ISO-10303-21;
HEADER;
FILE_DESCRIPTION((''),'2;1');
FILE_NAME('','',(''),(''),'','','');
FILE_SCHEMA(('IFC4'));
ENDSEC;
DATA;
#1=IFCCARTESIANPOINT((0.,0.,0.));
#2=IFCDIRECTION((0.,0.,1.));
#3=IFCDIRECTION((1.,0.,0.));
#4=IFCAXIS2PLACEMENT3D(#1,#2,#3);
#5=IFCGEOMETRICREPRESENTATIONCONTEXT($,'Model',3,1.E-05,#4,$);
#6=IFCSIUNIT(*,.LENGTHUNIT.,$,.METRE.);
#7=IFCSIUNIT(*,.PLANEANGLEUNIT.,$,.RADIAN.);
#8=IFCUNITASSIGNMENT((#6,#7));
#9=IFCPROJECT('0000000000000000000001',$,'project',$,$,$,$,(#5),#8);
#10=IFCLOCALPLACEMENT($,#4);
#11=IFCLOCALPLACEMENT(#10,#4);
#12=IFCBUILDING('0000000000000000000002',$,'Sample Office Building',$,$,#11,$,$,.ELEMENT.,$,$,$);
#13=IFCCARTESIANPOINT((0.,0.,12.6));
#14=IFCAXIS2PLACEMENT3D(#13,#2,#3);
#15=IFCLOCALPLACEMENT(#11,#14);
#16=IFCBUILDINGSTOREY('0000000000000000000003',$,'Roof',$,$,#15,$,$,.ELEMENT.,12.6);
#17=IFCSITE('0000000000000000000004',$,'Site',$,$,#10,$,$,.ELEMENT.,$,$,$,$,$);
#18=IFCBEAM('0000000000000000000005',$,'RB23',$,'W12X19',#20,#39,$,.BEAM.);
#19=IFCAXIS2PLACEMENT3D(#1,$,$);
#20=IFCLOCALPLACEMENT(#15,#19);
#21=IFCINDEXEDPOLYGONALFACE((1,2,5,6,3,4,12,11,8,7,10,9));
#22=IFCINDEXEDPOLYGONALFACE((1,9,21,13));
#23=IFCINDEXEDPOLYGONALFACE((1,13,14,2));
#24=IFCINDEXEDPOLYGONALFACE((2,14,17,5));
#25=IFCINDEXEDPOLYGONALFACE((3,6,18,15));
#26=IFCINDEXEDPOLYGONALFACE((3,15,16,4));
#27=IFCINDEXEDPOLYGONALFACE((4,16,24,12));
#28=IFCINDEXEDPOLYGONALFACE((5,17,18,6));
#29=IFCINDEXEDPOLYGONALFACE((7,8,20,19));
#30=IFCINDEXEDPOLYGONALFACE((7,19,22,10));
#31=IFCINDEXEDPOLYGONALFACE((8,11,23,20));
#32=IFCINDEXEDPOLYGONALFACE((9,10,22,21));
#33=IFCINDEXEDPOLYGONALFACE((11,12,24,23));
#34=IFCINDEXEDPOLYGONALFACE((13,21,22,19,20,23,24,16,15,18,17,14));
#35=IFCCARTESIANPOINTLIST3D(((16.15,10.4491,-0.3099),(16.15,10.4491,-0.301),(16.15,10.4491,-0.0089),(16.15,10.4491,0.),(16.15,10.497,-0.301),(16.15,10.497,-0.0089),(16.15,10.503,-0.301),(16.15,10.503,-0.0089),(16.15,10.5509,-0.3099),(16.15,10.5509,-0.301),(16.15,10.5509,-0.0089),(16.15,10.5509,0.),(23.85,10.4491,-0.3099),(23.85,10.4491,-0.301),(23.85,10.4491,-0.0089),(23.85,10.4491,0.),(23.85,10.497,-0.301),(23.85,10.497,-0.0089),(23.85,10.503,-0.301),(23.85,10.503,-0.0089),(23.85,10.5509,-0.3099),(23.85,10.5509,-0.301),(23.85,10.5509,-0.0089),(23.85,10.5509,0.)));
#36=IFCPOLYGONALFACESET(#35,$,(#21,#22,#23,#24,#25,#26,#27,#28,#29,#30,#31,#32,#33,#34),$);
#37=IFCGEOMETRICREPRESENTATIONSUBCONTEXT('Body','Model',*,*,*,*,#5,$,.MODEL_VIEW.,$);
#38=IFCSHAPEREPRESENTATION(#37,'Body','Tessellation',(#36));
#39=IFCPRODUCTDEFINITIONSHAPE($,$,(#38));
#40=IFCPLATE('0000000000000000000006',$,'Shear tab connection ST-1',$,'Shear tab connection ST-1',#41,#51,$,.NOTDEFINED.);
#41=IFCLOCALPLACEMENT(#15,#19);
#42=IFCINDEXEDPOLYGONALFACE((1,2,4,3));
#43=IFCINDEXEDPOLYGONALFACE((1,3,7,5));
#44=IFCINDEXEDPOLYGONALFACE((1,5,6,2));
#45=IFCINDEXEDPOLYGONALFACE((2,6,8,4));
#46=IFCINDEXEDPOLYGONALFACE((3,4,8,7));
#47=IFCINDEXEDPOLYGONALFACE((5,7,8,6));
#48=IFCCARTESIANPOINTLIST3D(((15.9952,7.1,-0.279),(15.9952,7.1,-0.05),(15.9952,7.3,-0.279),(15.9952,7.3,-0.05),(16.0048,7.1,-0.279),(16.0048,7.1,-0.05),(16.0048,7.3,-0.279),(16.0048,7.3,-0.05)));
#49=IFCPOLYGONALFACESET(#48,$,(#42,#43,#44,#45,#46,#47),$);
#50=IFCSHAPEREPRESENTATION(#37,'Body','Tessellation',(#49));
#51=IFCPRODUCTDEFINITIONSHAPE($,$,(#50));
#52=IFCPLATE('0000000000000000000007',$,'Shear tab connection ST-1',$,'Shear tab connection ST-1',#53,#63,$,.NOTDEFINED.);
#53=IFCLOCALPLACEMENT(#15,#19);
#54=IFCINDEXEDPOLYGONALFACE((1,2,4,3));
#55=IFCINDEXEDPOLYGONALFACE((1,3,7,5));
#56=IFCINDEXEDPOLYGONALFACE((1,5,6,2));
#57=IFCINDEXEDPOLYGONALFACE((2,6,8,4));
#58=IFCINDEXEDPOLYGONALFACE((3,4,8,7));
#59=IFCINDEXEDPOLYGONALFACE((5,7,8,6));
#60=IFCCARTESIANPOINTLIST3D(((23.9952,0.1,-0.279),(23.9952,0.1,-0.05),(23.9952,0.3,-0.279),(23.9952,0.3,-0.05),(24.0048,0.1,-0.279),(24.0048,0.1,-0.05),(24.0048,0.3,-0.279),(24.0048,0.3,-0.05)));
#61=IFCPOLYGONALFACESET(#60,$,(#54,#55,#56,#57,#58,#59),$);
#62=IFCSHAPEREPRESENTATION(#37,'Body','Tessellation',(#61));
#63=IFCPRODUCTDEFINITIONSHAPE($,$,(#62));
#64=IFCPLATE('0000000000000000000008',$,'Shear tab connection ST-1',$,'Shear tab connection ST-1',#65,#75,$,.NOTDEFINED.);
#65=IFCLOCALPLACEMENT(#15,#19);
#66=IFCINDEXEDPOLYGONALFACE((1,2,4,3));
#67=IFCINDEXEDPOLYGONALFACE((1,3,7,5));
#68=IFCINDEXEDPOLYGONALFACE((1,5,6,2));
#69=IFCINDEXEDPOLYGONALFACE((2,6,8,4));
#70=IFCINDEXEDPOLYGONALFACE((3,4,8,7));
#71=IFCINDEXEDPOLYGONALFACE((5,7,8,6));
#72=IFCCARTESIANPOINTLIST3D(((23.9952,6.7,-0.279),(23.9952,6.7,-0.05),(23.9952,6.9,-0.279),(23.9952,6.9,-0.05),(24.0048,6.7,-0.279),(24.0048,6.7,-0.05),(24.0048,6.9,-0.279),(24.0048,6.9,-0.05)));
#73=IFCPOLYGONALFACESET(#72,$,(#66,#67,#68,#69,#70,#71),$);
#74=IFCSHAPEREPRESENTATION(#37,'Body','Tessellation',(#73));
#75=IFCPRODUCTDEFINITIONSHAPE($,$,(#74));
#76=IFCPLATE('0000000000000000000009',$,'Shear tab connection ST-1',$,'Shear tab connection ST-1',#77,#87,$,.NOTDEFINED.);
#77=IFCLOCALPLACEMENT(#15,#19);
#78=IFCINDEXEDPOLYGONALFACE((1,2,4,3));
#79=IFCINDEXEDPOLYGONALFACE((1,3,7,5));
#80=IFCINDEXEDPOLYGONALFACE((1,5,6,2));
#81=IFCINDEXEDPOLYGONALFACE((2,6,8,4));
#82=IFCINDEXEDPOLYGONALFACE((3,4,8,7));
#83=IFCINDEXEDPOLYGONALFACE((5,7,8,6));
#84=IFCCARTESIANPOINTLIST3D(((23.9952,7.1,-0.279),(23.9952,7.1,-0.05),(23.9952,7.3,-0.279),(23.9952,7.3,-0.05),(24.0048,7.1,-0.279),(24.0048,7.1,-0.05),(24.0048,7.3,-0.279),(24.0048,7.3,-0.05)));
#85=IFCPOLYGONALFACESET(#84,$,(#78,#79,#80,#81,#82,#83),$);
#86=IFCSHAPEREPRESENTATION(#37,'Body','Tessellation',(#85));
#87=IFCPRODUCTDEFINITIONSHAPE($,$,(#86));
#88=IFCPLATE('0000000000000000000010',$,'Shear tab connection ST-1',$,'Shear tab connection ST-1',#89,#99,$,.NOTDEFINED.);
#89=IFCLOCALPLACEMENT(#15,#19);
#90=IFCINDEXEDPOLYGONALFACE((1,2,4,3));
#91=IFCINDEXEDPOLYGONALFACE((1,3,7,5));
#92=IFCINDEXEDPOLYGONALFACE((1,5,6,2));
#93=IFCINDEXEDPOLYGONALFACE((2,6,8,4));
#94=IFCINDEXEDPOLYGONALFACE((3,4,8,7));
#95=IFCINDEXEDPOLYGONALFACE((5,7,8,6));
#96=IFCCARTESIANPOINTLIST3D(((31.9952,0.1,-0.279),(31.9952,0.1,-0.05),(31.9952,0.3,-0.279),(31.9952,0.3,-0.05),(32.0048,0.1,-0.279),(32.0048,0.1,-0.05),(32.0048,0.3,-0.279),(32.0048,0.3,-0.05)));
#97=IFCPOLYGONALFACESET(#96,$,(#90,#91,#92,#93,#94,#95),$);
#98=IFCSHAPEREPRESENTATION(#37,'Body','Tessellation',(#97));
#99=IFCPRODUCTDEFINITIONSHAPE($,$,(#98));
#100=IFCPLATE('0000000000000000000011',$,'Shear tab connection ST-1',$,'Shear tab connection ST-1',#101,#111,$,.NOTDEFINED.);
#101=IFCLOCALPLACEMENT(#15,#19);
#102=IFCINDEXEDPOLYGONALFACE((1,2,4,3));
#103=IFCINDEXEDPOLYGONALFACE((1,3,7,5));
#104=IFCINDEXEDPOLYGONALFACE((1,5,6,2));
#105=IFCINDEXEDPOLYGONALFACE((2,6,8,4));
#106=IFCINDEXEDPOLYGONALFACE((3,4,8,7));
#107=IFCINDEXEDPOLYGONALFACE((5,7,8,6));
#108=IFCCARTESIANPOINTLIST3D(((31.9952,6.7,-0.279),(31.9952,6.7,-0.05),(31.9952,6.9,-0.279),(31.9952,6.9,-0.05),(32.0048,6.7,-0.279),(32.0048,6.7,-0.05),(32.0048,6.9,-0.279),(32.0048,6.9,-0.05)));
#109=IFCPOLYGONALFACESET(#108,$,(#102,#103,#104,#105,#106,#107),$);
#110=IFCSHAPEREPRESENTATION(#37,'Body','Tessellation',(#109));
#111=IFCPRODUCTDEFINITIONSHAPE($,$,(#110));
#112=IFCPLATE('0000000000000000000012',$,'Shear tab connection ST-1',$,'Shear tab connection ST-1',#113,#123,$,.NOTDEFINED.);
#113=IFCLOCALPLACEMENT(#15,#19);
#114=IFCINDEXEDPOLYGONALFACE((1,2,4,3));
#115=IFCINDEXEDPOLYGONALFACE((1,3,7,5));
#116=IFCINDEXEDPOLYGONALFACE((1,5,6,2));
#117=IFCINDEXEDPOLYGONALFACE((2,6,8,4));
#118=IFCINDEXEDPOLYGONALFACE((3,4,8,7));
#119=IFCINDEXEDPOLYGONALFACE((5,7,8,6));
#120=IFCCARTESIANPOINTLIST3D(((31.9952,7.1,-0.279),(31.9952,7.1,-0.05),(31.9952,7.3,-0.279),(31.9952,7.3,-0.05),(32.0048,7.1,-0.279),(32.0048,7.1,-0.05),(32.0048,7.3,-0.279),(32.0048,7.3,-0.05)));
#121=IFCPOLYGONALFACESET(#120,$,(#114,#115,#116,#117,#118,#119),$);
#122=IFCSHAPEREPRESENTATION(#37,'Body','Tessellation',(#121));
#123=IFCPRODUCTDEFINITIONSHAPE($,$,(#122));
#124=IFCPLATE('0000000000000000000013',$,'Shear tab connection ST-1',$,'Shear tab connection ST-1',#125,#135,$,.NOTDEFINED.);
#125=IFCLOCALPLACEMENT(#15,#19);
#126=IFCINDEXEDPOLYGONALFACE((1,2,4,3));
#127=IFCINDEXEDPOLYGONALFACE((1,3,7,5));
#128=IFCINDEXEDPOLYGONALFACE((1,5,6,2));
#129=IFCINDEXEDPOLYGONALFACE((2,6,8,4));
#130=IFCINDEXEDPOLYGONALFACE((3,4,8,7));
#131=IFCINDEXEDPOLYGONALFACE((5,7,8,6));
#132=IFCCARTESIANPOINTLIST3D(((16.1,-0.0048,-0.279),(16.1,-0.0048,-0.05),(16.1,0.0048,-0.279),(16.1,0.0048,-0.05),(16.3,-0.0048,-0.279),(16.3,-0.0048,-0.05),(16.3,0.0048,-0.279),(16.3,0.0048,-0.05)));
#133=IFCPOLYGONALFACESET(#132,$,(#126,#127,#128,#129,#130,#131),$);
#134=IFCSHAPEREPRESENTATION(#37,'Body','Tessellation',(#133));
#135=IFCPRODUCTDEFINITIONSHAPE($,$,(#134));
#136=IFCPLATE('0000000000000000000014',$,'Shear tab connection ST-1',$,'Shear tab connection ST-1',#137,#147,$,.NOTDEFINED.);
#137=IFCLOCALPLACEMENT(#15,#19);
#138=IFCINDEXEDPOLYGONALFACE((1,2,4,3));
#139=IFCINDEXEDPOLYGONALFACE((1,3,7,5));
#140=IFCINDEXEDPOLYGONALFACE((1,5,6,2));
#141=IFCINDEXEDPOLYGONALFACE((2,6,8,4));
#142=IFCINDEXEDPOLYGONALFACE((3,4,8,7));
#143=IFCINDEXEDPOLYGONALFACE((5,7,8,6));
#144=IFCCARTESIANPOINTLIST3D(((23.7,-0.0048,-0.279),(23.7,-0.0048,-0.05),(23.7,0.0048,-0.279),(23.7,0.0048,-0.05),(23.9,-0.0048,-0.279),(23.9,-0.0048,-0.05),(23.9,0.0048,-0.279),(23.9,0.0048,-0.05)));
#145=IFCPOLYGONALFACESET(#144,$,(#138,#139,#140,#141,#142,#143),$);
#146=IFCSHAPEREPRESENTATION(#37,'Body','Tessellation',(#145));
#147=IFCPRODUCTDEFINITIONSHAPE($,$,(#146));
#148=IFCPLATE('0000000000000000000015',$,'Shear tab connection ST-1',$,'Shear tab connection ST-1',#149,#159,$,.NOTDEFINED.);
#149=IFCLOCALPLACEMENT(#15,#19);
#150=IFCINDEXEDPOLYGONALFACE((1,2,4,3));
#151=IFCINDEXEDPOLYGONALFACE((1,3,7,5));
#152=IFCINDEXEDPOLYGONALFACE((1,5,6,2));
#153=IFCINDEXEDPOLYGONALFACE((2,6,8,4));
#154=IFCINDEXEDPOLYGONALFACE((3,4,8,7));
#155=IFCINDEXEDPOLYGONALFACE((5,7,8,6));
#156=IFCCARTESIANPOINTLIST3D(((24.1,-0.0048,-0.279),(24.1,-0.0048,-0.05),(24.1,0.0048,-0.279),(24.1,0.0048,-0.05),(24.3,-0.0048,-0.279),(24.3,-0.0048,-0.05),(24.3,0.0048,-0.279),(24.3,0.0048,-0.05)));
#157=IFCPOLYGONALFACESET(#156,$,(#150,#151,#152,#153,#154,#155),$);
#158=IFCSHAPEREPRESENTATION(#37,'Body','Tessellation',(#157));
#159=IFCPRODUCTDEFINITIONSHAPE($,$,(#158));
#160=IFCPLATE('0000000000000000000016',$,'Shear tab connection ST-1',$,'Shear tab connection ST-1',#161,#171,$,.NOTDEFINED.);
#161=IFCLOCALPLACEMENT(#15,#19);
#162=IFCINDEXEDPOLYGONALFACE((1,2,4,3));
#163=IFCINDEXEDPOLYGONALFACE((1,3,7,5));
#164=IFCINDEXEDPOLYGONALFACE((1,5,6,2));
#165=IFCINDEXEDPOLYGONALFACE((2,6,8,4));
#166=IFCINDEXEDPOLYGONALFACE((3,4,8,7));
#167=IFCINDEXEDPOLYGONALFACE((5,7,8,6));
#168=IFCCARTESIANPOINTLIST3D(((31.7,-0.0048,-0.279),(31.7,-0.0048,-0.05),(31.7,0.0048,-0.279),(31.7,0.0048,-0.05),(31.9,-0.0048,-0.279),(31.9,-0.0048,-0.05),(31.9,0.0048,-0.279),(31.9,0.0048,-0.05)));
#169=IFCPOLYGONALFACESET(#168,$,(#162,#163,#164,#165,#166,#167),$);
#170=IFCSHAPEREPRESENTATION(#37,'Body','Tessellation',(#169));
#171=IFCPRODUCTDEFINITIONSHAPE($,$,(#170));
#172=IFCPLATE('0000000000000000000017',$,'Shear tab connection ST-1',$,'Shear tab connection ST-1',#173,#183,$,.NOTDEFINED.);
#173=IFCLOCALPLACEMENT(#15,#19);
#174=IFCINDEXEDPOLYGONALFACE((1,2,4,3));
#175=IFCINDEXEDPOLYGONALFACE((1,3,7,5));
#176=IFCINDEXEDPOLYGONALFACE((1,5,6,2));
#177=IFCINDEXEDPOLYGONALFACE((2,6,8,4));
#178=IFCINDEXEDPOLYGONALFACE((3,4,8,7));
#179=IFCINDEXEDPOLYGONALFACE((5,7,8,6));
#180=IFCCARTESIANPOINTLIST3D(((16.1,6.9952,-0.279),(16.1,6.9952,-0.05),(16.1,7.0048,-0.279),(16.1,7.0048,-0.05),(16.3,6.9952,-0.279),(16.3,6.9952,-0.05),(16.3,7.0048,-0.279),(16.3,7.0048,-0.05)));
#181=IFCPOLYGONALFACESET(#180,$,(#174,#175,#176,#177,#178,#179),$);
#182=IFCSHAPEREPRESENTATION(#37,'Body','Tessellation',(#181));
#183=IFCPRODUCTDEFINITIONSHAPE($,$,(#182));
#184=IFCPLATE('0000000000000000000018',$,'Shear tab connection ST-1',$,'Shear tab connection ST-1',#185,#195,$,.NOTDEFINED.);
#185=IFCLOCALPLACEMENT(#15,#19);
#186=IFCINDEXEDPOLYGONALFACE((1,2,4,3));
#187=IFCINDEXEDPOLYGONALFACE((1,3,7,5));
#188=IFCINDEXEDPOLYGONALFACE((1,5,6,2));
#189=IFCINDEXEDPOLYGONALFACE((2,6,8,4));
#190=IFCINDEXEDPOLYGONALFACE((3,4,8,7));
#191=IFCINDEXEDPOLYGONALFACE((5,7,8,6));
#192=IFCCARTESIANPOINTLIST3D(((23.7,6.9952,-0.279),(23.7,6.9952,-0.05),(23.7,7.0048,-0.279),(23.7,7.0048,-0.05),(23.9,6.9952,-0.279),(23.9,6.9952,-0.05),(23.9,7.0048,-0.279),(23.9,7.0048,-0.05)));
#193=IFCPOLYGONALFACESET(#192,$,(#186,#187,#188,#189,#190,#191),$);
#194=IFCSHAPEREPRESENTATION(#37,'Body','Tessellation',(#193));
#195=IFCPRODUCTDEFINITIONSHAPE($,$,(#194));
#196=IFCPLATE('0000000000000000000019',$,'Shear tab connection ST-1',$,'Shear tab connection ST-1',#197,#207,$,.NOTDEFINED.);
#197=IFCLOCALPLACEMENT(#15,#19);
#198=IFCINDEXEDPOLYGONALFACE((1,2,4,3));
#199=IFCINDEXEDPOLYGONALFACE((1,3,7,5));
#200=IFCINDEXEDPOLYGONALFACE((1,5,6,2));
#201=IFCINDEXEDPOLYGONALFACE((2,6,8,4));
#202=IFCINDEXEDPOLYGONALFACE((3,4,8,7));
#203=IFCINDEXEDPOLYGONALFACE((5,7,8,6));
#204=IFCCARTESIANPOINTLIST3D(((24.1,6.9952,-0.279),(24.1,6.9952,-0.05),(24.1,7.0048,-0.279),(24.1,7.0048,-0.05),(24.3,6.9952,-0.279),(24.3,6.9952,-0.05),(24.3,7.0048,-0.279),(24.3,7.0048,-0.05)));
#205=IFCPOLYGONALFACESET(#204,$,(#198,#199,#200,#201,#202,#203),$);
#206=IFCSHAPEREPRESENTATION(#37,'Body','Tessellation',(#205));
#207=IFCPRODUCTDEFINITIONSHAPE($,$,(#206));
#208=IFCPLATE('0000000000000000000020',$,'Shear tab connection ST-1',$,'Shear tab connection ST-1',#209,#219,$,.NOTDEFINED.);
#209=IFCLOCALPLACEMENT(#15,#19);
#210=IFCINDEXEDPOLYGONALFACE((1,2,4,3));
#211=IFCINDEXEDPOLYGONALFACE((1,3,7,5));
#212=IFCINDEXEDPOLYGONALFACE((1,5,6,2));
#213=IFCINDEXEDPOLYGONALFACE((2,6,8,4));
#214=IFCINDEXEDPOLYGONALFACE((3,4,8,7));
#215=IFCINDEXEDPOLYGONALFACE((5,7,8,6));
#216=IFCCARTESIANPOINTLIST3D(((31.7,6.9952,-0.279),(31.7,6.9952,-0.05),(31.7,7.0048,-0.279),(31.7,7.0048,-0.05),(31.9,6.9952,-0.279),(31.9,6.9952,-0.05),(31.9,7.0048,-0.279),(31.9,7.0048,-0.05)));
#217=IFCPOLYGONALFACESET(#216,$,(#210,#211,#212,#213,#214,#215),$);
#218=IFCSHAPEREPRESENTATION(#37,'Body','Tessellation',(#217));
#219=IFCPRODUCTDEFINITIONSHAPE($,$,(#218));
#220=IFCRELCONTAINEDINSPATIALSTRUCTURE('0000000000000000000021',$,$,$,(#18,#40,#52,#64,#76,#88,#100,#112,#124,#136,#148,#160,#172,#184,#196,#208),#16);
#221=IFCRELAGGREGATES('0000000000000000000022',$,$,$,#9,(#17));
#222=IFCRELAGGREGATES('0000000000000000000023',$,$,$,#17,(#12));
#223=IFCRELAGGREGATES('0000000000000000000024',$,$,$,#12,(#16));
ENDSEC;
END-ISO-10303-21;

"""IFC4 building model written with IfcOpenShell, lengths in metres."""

from ifc_helpers import new_model, si_unit, frame, origin_with_axes, place, context, subcontext, project, spatial, rectangle, i_section, extrude, element, save


model = new_model("IFC4")

# Units and contexts
model_context = context("Model", 3, precision=1e-05, world=origin_with_axes())
body_context = subcontext(model_context, "Body", "Model", "MODEL_VIEW")
ifc_project = project(units=[si_unit("LENGTHUNIT", "METRE"), si_unit("PLANEANGLEUNIT", "RADIAN")], contexts=[model_context])

# Site, building, storey
site_placement = place(None, origin_with_axes())
site = spatial("IfcSite", under=ifc_project, at=site_placement, Name="Site", CompositionType="ELEMENT")
building_placement = place(site_placement, origin_with_axes())
building = spatial("IfcBuilding", under=site, at=building_placement, Name="Sample Office Building", CompositionType="ELEMENT")
storey_placement = place(building_placement, frame((0.0, 0.0, 12.6), z_axis=(0.0, 0.0, 1.0), x_axis=(1.0, 0.0, 0.0)))
storey = spatial("IfcBuildingStorey", under=building, at=storey_placement, Name="Roof", CompositionType="ELEMENT", Elevation=12.6)

# Beam
for number, where, z_axis, x_axis, name in (
    (1, (16.15, 10.5, 12.4451), (1.0, 0.0, 0.0), (0.0, 1.0, 0.0), "RB23"),
):
    element("IfcBeam", number, at=place(None, frame(where, z_axis=z_axis, x_axis=x_axis)), inside=storey, Name=name, ObjectType="W12X19", PredefinedType="BEAM", context=body_context, shape_type="SweptSolid", body=[
        extrude(i_section(OverallWidth=0.1019, OverallDepth=0.3099, WebThickness=0.006, FlangeThickness=0.0089), None, (0.0, 0.0, 1.0), 7.7),
    ])

# Plates
plate_1_placement = place(None, frame((16.0, 7.2, 12.321), z_axis=(0.0, 0.0, 1.0), x_axis=(1.0, 0.0, 0.0)))
element("IfcPlate", 2, at=plate_1_placement, inside=storey, Name="Shear tab connection ST-1", ObjectType="Shear tab connection ST-1", PredefinedType="NOTDEFINED", context=body_context, shape_type="SweptSolid", body=[
    extrude(rectangle(XDim=0.0095, YDim=0.2), None, (0.0, 0.0, 1.0), 0.229),
])
plate_2_placement = place(None, frame((24.0, 0.2, 12.321), z_axis=(0.0, 0.0, 1.0), x_axis=(1.0, 0.0, 0.0)))
element("IfcPlate", 3, at=plate_2_placement, inside=storey, Name="Shear tab connection ST-1", ObjectType="Shear tab connection ST-1", PredefinedType="NOTDEFINED", context=body_context, shape_type="SweptSolid", body=[
    extrude(rectangle(XDim=0.0095, YDim=0.2), None, (0.0, 0.0, 1.0), 0.229),
])
for number, where, z_axis, x_axis, name in (
    (4, (24.0, 6.8, 12.321), (0.0, 0.0, 1.0), (1.0, 0.0, 0.0), "Shear tab connection ST-1"),
    (5, (24.0, 7.2, 12.321), (0.0, 0.0, 1.0), (1.0, 0.0, 0.0), "Shear tab connection ST-1"),
):
    element("IfcPlate", number, at=place(None, frame(where, z_axis=z_axis, x_axis=x_axis)), inside=storey, Name=name, ObjectType="Shear tab connection ST-1", PredefinedType="NOTDEFINED", context=body_context, shape_type="SweptSolid", body=[
        extrude(rectangle(XDim=0.0095, YDim=0.2), None, (0.0, 0.0, 1.0), 0.229),
    ])
plate_3_placement = place(None, frame((32.0, 0.2, 12.321), z_axis=(0.0, 0.0, 1.0), x_axis=(1.0, 0.0, 0.0)))
element("IfcPlate", 6, at=plate_3_placement, inside=storey, Name="Shear tab connection ST-1", ObjectType="Shear tab connection ST-1", PredefinedType="NOTDEFINED", context=body_context, shape_type="SweptSolid", body=[
    extrude(rectangle(XDim=0.0095, YDim=0.2), None, (0.0, 0.0, 1.0), 0.229),
])
for number, where, z_axis, x_axis, name in (
    (7, (32.0, 6.8, 12.321), (0.0, 0.0, 1.0), (1.0, 0.0, 0.0), "Shear tab connection ST-1"),
    (8, (32.0, 7.2, 12.321), (0.0, 0.0, 1.0), (1.0, 0.0, 0.0), "Shear tab connection ST-1"),
):
    element("IfcPlate", number, at=place(None, frame(where, z_axis=z_axis, x_axis=x_axis)), inside=storey, Name=name, ObjectType="Shear tab connection ST-1", PredefinedType="NOTDEFINED", context=body_context, shape_type="SweptSolid", body=[
        extrude(rectangle(XDim=0.0095, YDim=0.2), None, (0.0, 0.0, 1.0), 0.229),
    ])
for number, where, z_axis, x_axis, name in (
    (9, (16.2, 0.0, 12.321), (0.0, 0.0, 1.0), (1.0, 0.0, 0.0), "Shear tab connection ST-1"),
    (10, (23.8, 0.0, 12.321), (0.0, 0.0, 1.0), (1.0, 0.0, 0.0), "Shear tab connection ST-1"),
    (11, (24.2, 0.0, 12.321), (0.0, 0.0, 1.0), (1.0, 0.0, 0.0), "Shear tab connection ST-1"),
    (12, (31.8, 0.0, 12.321), (0.0, 0.0, 1.0), (1.0, 0.0, 0.0), "Shear tab connection ST-1"),
):
    element("IfcPlate", number, at=place(None, frame(where, z_axis=z_axis, x_axis=x_axis)), inside=storey, Name=name, ObjectType="Shear tab connection ST-1", PredefinedType="NOTDEFINED", context=body_context, shape_type="SweptSolid", body=[
        extrude(rectangle(XDim=0.2, YDim=0.0095), None, (0.0, 0.0, 1.0), 0.229),
    ])
for number, where, z_axis, x_axis, name in (
    (13, (16.2, 7.0, 12.321), (0.0, 0.0, 1.0), (1.0, 0.0, 0.0), "Shear tab connection ST-1"),
    (14, (23.8, 7.0, 12.321), (0.0, 0.0, 1.0), (1.0, 0.0, 0.0), "Shear tab connection ST-1"),
    (15, (24.2, 7.0, 12.321), (0.0, 0.0, 1.0), (1.0, 0.0, 0.0), "Shear tab connection ST-1"),
    (16, (31.8, 7.0, 12.321), (0.0, 0.0, 1.0), (1.0, 0.0, 0.0), "Shear tab connection ST-1"),
):
    element("IfcPlate", number, at=place(None, frame(where, z_axis=z_axis, x_axis=x_axis)), inside=storey, Name=name, ObjectType="Shear tab connection ST-1", PredefinedType="NOTDEFINED", context=body_context, shape_type="SweptSolid", body=[
        extrude(rectangle(XDim=0.2, YDim=0.0095), None, (0.0, 0.0, 1.0), 0.229),
    ])

save(model, "model.ifc")
